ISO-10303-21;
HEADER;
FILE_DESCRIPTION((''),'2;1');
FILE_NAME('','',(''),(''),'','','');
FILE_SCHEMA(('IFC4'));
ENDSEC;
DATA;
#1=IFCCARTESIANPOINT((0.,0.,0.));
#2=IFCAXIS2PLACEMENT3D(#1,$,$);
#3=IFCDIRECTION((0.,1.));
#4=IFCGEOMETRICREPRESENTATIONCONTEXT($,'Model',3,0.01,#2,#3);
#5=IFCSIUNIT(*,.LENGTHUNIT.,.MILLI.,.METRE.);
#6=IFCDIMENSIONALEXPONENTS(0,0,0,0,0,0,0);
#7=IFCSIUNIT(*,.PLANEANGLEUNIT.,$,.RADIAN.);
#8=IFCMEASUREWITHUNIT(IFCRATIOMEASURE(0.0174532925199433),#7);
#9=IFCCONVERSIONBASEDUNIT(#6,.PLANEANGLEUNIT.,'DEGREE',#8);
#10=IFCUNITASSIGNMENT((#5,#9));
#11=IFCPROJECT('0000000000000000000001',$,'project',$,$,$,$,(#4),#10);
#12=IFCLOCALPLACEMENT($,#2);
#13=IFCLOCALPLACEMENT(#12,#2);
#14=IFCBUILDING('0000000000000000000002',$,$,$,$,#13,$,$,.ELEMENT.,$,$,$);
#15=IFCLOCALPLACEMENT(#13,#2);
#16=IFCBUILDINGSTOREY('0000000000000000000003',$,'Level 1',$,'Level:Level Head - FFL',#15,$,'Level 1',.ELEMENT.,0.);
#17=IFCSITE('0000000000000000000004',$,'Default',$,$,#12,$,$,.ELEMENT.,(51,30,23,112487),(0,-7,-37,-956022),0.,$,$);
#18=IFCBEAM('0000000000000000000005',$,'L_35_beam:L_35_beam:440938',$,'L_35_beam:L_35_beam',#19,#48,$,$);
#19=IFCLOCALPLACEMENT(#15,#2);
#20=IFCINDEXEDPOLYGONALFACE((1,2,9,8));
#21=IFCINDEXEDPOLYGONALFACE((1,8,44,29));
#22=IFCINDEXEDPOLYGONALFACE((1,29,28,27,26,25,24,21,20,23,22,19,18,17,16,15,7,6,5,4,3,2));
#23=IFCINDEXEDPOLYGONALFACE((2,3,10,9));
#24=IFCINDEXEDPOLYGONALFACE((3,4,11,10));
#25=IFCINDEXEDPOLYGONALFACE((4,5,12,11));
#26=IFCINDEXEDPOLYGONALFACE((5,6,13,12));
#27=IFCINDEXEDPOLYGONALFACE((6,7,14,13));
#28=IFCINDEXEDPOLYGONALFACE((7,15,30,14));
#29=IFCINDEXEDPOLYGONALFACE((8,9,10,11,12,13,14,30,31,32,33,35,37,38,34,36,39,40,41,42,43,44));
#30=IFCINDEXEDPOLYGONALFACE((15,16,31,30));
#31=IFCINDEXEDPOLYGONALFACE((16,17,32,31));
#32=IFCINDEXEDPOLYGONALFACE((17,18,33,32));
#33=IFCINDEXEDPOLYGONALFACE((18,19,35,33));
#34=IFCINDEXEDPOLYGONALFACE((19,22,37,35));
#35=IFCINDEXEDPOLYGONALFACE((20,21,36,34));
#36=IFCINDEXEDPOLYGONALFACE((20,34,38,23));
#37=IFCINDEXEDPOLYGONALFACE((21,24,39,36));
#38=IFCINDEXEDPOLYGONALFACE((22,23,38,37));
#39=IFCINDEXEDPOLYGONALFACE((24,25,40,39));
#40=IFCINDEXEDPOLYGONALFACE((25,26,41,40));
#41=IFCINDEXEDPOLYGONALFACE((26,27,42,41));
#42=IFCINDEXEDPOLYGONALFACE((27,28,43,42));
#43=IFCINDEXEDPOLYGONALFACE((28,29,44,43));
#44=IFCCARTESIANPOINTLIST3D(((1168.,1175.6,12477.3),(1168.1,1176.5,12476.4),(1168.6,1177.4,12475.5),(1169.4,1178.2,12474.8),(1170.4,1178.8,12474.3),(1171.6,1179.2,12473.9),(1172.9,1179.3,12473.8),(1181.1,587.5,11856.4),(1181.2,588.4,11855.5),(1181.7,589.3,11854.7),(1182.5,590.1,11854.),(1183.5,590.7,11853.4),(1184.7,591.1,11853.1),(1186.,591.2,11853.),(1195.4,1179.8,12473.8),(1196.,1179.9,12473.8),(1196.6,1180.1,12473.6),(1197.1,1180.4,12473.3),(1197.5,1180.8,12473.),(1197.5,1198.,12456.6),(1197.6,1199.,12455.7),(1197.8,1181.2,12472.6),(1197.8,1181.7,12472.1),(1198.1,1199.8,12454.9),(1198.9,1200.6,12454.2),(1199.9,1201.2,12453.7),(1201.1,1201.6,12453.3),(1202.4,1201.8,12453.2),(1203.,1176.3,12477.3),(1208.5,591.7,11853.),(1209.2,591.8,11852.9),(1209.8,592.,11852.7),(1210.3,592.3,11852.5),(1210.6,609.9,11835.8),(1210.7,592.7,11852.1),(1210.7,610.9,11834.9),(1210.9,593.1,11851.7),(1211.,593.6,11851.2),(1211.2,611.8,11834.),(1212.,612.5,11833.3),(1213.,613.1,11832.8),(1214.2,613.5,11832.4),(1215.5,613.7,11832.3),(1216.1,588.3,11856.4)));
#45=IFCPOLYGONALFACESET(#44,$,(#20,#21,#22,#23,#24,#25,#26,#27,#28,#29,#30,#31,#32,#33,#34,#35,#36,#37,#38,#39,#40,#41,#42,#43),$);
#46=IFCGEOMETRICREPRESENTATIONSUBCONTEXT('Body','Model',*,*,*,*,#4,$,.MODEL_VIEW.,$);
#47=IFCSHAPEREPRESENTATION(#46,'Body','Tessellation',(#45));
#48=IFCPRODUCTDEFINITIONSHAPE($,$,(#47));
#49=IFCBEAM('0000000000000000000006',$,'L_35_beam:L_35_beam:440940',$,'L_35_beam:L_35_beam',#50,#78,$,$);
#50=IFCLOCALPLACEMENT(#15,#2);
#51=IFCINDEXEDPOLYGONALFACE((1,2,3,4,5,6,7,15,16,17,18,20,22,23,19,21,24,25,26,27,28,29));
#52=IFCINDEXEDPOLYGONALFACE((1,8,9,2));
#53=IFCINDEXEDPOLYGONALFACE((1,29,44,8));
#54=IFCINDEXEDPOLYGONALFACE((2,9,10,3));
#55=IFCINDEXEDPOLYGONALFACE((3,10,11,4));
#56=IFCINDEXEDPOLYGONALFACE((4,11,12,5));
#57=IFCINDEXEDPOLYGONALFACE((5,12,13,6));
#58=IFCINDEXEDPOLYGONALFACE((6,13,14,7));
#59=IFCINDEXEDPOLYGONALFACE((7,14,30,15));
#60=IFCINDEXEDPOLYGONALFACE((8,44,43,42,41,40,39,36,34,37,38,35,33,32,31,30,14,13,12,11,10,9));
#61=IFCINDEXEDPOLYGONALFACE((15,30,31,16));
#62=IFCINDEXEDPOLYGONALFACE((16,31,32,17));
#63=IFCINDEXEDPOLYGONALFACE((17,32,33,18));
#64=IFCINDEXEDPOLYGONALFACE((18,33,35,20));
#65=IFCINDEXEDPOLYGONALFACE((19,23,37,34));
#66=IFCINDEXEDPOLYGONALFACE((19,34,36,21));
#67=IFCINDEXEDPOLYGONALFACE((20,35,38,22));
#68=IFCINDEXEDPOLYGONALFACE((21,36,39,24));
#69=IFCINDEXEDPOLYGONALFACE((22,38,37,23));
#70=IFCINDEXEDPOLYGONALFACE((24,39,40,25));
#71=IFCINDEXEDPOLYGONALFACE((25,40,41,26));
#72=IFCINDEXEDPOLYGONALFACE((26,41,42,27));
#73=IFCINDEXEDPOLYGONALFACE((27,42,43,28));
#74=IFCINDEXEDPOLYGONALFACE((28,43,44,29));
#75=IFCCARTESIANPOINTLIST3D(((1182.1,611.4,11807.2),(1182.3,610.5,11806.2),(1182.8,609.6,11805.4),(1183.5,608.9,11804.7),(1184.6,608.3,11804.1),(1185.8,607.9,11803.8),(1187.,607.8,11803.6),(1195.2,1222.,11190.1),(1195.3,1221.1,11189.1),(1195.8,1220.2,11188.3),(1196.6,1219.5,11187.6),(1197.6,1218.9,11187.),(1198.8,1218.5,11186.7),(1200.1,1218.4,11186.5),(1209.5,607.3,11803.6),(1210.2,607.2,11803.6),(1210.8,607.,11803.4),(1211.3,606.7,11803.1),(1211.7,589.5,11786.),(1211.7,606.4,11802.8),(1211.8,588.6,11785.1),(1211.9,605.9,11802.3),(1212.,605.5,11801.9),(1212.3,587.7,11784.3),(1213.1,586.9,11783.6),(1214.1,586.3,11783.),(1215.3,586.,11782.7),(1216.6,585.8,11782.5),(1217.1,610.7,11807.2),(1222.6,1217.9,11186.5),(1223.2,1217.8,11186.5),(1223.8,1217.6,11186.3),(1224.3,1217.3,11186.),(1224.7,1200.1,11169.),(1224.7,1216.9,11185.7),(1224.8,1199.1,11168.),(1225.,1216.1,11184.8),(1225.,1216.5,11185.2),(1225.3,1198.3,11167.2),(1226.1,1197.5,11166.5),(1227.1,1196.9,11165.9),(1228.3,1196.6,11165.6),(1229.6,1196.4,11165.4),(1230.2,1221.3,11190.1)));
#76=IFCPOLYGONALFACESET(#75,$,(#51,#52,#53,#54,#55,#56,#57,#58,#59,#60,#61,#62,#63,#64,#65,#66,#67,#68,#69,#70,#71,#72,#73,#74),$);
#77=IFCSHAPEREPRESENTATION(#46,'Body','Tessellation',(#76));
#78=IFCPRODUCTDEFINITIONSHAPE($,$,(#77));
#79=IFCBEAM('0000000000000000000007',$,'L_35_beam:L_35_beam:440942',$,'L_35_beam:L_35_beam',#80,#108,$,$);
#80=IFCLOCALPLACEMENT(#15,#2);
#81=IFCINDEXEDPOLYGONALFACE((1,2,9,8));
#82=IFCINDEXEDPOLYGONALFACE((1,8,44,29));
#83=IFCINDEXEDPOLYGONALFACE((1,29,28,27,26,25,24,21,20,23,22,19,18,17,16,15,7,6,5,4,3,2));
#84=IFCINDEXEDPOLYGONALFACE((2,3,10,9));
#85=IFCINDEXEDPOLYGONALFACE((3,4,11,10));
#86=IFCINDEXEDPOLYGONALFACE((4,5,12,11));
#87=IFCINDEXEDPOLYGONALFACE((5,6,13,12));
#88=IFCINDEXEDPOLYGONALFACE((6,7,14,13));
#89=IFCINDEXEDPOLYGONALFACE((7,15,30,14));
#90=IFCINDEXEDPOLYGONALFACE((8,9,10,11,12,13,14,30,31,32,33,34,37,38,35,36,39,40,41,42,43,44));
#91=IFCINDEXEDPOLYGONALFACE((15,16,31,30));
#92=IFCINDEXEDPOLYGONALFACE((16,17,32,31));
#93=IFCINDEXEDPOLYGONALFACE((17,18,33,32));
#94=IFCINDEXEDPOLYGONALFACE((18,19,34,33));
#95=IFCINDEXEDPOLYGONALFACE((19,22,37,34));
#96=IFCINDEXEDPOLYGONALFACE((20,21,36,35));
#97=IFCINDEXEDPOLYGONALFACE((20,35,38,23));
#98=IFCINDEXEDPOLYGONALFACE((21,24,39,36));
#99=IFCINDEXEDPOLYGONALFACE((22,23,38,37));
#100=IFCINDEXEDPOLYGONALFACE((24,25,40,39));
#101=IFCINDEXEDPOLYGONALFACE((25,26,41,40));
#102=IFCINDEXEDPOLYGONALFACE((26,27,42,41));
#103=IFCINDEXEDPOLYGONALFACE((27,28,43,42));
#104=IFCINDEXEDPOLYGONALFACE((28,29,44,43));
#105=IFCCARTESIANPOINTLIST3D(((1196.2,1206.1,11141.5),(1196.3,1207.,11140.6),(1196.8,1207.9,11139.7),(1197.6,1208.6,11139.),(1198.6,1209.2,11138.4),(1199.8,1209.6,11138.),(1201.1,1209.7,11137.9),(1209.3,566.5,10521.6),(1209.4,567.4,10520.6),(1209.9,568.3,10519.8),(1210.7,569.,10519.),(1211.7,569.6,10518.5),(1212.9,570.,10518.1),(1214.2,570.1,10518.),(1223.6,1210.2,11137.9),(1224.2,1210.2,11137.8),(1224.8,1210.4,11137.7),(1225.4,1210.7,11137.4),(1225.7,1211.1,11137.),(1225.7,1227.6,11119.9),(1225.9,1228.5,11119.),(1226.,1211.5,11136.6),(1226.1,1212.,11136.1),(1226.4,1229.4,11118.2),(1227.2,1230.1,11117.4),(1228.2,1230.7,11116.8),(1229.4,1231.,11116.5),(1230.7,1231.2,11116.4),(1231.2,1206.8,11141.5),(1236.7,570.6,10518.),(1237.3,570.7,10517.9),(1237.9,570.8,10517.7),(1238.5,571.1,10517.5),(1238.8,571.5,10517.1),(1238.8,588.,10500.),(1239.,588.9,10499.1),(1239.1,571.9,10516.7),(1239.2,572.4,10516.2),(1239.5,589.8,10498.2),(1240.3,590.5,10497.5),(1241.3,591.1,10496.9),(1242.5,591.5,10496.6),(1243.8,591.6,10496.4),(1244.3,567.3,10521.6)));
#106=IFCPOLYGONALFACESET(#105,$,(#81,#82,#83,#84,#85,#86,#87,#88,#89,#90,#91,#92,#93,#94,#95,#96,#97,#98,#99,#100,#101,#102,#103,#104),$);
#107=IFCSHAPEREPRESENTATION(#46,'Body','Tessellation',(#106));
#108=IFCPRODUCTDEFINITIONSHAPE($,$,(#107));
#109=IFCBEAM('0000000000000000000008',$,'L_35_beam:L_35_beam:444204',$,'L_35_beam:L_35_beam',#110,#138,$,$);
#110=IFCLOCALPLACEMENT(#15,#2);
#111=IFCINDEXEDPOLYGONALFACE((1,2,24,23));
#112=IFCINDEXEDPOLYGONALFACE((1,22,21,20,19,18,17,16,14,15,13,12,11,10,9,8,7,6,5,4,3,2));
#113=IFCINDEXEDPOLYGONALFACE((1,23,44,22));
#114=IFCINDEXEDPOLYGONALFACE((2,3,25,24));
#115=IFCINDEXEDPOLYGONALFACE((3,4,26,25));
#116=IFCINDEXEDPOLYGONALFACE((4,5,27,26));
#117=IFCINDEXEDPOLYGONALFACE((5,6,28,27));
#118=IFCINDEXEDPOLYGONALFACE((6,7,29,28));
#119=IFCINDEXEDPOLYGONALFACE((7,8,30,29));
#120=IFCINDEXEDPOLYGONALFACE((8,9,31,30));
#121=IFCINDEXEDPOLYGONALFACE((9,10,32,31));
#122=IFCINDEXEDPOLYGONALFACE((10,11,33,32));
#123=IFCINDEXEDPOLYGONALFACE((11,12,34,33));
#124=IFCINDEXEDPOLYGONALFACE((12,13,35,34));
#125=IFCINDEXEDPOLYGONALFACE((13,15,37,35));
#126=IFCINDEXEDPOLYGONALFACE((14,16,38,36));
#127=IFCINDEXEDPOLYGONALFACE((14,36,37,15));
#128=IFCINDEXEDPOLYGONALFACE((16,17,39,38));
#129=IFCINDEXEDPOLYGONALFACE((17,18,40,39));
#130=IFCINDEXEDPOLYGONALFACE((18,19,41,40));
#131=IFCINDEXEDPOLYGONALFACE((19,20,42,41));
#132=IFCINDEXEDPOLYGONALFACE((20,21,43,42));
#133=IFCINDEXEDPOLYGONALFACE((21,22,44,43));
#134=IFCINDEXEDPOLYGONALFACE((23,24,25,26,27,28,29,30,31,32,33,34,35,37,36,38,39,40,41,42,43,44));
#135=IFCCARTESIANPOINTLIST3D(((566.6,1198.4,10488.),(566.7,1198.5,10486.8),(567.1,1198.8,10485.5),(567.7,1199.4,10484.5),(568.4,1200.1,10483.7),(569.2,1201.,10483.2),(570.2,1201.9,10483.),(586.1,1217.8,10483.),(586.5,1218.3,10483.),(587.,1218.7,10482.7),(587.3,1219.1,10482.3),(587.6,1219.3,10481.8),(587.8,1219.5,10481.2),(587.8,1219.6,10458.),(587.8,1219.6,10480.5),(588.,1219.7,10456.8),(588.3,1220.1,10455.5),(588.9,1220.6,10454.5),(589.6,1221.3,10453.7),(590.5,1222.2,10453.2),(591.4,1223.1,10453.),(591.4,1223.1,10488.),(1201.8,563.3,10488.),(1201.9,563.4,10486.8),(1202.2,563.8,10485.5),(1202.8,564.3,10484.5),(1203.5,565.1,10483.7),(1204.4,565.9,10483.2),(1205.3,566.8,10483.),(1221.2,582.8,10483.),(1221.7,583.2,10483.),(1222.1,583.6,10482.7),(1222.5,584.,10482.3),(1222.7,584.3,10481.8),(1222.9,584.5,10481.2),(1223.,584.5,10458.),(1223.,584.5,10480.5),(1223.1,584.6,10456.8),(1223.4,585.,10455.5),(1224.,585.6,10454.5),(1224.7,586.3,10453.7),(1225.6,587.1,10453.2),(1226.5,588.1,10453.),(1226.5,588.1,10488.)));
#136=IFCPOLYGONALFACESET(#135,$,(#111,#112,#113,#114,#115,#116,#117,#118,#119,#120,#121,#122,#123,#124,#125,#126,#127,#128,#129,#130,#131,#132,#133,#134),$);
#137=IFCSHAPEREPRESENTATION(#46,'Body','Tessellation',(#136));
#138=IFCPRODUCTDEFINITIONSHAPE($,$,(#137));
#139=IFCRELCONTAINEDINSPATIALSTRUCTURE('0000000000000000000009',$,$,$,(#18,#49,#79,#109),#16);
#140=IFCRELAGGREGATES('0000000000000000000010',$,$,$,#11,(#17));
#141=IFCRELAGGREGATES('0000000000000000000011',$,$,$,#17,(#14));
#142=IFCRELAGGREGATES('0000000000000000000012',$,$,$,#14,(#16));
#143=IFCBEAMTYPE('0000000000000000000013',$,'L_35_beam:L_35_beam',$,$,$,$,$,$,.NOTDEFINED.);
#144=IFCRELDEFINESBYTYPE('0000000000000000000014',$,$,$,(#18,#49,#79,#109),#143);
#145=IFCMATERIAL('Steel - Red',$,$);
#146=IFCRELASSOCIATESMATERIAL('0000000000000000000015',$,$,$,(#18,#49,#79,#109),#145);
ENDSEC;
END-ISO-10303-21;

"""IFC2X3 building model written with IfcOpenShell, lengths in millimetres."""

from ifc_helpers import new_model, entity, si_unit, converted_unit, direction, frame, frame_2d, origin, place, context, subcontext, project, spatial, polyline, circle_curve, parameter, trimmed, segment, composite_curve, outline, extrude, material, type_object, element, save


model = new_model("IFC2X3")

# Units and contexts
model_context = context("Model", 3, precision=0.01, world=origin(), true_north=direction((0.0, 1.0)))
body_context = subcontext(model_context, "Body", "Model", "MODEL_VIEW")
ifc_project = project(units=[si_unit("LENGTHUNIT", "METRE", prefix="MILLI"), converted_unit("PLANEANGLEUNIT", "DEGREE", entity("IfcRatioMeasure", 0.0174532925199433), si_unit("PLANEANGLEUNIT", "RADIAN"), dimensions=[0, 0, 0, 0, 0, 0, 0])], contexts=[model_context])

# Site, building, storey
site_placement = place(None, origin())
site = spatial("IfcSite", under=ifc_project, at=site_placement, Name="Default", CompositionType="ELEMENT", RefLatitude=(51, 30, 23, 112487), RefLongitude=(0, -7, -37, -956022), RefElevation=0.0)
building_placement = place(site_placement, origin())
building = spatial("IfcBuilding", under=site, at=building_placement, CompositionType="ELEMENT")
storey_placement = place(building_placement, origin())
storey = spatial("IfcBuildingStorey", under=building, at=storey_placement, Name="Level 1", ObjectType="Level:Level Head - FFL", LongName="Level 1", CompositionType="ELEMENT", Elevation=0.0)

# Beams
ifc_material_1 = material(Name="Steel - Red")
beam_type_1 = type_object("IfcBeamType", Name="L_35_beam:L_35_beam", PredefinedType="NOTDEFINED")
beam_1_placement = place(storey_placement, frame((1210.2, 1210.2, 12487.3), z_axis=(0.999882, 0.010548, 0.011136), x_axis=(0.015339, -0.687593, -0.725934)))
element("IfcBeam", 1, at=beam_1_placement, inside=storey, type_object=beam_type_1, material=ifc_material_1, Name="L_35_beam:L_35_beam:440938", ObjectType="L_35_beam:L_35_beam", context=body_context, shape_type="SweptSolid", body=[
    extrude(outline(composite_curve([segment(polyline([(-23.2, -11.8), (11.8, -11.8)]), True, "CONTINUOUS"), segment(polyline([(11.8, -11.8), (11.8, 23.2)]), True, "CONTINUOUS"), segment(trimmed(circle_curve(frame_2d((11.8, 18.2), x_axis=(0.0, 1.0)), 5.0), [parameter(0.0)], [parameter(90.0)], True, "PARAMETER"), True, "CONTINUOUS"), segment(polyline([(6.8, 18.2), (6.8, -4.3)]), True, "CONTINUOUS"), segment(trimmed(circle_curve(frame_2d((4.3, -4.3), x_axis=(1.0, 0.0)), 2.5), [parameter(270.0)], [parameter(0.0)], True, "PARAMETER"), False, "CONTINUOUS"), segment(polyline([(4.3, -6.8), (-18.2, -6.8)]), True, "CONTINUOUS"), segment(trimmed(circle_curve(frame_2d((-18.2, -11.8), x_axis=(0.0, 1.0)), 5.0), [parameter(0.0)], [parameter(90.0)], True, "PARAMETER"), True, "CONTINUOUS")], self_intersect=False)), frame((30.4, -6.0, -19.7), z_axis=(1.0, 0.0, 0.0), x_axis=(0.0, -0.999869, 0.016192)), (0.0, 0.0, 1.0), 855.3),
])
beam_2_placement = place(storey_placement, frame((1238.5, 1238.5, 11147.6), z_axis=(0.999887, -0.010563, 0.010676), x_axis=(-0.015018, -0.703269, 0.710765)))
element("IfcBeam", 2, at=beam_2_placement, inside=storey, type_object=beam_type_1, material=ifc_material_1, Name="L_35_beam:L_35_beam:440940", ObjectType="L_35_beam:L_35_beam", context=body_context, shape_type="SweptSolid", body=[
    extrude(outline(composite_curve([segment(polyline([(-23.2, -11.8), (11.8, -11.8)]), True, "CONTINUOUS"), segment(polyline([(11.8, -11.8), (11.8, 23.2)]), True, "CONTINUOUS"), segment(trimmed(circle_curve(frame_2d((11.8, 18.2), x_axis=(0.0, 1.0)), 5.0), [parameter(0.0)], [parameter(90.0)], True, "PARAMETER"), True, "CONTINUOUS"), segment(polyline([(6.8, 18.2), (6.8, -4.3)]), True, "CONTINUOUS"), segment(trimmed(circle_curve(frame_2d((4.3, -4.3), x_axis=(1.0, 0.0)), 2.5), [parameter(270.0)], [parameter(0.0)], True, "PARAMETER"), False, "CONTINUOUS"), segment(polyline([(4.3, -6.8), (-18.2, -6.8)]), True, "CONTINUOUS"), segment(trimmed(circle_curve(frame_2d((-18.2, -11.8), x_axis=(0.0, 1.0)), 5.0), [parameter(0.0)], [parameter(90.0)], True, "PARAMETER"), True, "CONTINUOUS")], self_intersect=False)), frame((42.4, -6.0, -19.7), z_axis=(1.0, 0.0, 0.0), x_axis=(0.0, -0.999885, 0.015176)), (0.0, 0.0, 1.0), 868.2),
])
beam_3_placement = place(storey_placement, frame((1238.5, 1238.5, 11147.6), z_axis=(0.014249, -0.695761, 0.718132), x_axis=(0.014704, -0.717982, -0.695907)))
element("IfcBeam", 3, at=beam_3_placement, inside=storey, type_object=beam_type_1, material=ifc_material_1, Name="L_35_beam:L_35_beam:440942", ObjectType="L_35_beam:L_35_beam", context=body_context, shape_type="SweptSolid", body=[
    extrude(outline(composite_curve([segment(polyline([(-23.2, -11.8), (11.8, -11.8)]), True, "CONTINUOUS"), segment(polyline([(11.8, -11.8), (11.8, 23.2)]), True, "CONTINUOUS"), segment(trimmed(circle_curve(frame_2d((11.8, 18.2), x_axis=(0.0, 1.0)), 5.0), [parameter(0.0)], [parameter(90.0)], True, "PARAMETER"), True, "CONTINUOUS"), segment(polyline([(6.8, 18.2), (6.8, -4.3)]), True, "CONTINUOUS"), segment(trimmed(circle_curve(frame_2d((4.3, -4.3), x_axis=(1.0, 0.0)), 2.5), [parameter(270.0)], [parameter(0.0)], True, "PARAMETER"), False, "CONTINUOUS"), segment(polyline([(4.3, -6.8), (-18.2, -6.8)]), True, "CONTINUOUS"), segment(trimmed(circle_curve(frame_2d((-18.2, -11.8), x_axis=(0.0, 1.0)), 5.0), [parameter(0.0)], [parameter(90.0)], True, "PARAMETER"), True, "CONTINUOUS")], self_intersect=False)), frame((26.9, -19.8, 5.7), z_axis=(1.0, 0.0, 0.0), x_axis=(0.0, 0.0, 1.0)), (0.0, 0.0, 1.0), 890.8),
])
beam_4_placement = place(storey_placement, frame((547.3, 1252.6, 10477.8), z_axis=(0.0, 0.0, 1.0), x_axis=(0.707154, -0.70706, 0.0)))
element("IfcBeam", 4, at=beam_4_placement, inside=storey, type_object=beam_type_1, material=ifc_material_1, Name="L_35_beam:L_35_beam:444204", ObjectType="L_35_beam:L_35_beam", context=body_context, shape_type="SweptSolid", body=[
    extrude(outline(composite_curve([segment(polyline([(-23.2, -11.8), (11.8, -11.8)]), True, "CONTINUOUS"), segment(polyline([(11.8, -11.8), (11.8, 23.2)]), True, "CONTINUOUS"), segment(trimmed(circle_curve(frame_2d((11.8, 18.2), x_axis=(0.0, 1.0)), 5.0), [parameter(0.0)], [parameter(90.0)], True, "PARAMETER"), True, "CONTINUOUS"), segment(polyline([(6.8, 18.2), (6.8, -4.3)]), True, "CONTINUOUS"), segment(trimmed(circle_curve(frame_2d((4.3, -4.3), x_axis=(1.0, 0.0)), 2.5), [parameter(270.0)], [parameter(0.0)], True, "PARAMETER"), False, "CONTINUOUS"), segment(polyline([(4.3, -6.8), (-18.2, -6.8)]), True, "CONTINUOUS"), segment(trimmed(circle_curve(frame_2d((-18.2, -11.8), x_axis=(0.0, 1.0)), 5.0), [parameter(0.0)], [parameter(90.0)], True, "PARAMETER"), True, "CONTINUOUS")], self_intersect=False)), frame((52.0, -1.5, -1.5), z_axis=(1.0, 0.0, 0.0), x_axis=(0.0, 0.0, 1.0)), (0.0, 0.0, 1.0), 898.2),
])

save(model, "model.ifc")
